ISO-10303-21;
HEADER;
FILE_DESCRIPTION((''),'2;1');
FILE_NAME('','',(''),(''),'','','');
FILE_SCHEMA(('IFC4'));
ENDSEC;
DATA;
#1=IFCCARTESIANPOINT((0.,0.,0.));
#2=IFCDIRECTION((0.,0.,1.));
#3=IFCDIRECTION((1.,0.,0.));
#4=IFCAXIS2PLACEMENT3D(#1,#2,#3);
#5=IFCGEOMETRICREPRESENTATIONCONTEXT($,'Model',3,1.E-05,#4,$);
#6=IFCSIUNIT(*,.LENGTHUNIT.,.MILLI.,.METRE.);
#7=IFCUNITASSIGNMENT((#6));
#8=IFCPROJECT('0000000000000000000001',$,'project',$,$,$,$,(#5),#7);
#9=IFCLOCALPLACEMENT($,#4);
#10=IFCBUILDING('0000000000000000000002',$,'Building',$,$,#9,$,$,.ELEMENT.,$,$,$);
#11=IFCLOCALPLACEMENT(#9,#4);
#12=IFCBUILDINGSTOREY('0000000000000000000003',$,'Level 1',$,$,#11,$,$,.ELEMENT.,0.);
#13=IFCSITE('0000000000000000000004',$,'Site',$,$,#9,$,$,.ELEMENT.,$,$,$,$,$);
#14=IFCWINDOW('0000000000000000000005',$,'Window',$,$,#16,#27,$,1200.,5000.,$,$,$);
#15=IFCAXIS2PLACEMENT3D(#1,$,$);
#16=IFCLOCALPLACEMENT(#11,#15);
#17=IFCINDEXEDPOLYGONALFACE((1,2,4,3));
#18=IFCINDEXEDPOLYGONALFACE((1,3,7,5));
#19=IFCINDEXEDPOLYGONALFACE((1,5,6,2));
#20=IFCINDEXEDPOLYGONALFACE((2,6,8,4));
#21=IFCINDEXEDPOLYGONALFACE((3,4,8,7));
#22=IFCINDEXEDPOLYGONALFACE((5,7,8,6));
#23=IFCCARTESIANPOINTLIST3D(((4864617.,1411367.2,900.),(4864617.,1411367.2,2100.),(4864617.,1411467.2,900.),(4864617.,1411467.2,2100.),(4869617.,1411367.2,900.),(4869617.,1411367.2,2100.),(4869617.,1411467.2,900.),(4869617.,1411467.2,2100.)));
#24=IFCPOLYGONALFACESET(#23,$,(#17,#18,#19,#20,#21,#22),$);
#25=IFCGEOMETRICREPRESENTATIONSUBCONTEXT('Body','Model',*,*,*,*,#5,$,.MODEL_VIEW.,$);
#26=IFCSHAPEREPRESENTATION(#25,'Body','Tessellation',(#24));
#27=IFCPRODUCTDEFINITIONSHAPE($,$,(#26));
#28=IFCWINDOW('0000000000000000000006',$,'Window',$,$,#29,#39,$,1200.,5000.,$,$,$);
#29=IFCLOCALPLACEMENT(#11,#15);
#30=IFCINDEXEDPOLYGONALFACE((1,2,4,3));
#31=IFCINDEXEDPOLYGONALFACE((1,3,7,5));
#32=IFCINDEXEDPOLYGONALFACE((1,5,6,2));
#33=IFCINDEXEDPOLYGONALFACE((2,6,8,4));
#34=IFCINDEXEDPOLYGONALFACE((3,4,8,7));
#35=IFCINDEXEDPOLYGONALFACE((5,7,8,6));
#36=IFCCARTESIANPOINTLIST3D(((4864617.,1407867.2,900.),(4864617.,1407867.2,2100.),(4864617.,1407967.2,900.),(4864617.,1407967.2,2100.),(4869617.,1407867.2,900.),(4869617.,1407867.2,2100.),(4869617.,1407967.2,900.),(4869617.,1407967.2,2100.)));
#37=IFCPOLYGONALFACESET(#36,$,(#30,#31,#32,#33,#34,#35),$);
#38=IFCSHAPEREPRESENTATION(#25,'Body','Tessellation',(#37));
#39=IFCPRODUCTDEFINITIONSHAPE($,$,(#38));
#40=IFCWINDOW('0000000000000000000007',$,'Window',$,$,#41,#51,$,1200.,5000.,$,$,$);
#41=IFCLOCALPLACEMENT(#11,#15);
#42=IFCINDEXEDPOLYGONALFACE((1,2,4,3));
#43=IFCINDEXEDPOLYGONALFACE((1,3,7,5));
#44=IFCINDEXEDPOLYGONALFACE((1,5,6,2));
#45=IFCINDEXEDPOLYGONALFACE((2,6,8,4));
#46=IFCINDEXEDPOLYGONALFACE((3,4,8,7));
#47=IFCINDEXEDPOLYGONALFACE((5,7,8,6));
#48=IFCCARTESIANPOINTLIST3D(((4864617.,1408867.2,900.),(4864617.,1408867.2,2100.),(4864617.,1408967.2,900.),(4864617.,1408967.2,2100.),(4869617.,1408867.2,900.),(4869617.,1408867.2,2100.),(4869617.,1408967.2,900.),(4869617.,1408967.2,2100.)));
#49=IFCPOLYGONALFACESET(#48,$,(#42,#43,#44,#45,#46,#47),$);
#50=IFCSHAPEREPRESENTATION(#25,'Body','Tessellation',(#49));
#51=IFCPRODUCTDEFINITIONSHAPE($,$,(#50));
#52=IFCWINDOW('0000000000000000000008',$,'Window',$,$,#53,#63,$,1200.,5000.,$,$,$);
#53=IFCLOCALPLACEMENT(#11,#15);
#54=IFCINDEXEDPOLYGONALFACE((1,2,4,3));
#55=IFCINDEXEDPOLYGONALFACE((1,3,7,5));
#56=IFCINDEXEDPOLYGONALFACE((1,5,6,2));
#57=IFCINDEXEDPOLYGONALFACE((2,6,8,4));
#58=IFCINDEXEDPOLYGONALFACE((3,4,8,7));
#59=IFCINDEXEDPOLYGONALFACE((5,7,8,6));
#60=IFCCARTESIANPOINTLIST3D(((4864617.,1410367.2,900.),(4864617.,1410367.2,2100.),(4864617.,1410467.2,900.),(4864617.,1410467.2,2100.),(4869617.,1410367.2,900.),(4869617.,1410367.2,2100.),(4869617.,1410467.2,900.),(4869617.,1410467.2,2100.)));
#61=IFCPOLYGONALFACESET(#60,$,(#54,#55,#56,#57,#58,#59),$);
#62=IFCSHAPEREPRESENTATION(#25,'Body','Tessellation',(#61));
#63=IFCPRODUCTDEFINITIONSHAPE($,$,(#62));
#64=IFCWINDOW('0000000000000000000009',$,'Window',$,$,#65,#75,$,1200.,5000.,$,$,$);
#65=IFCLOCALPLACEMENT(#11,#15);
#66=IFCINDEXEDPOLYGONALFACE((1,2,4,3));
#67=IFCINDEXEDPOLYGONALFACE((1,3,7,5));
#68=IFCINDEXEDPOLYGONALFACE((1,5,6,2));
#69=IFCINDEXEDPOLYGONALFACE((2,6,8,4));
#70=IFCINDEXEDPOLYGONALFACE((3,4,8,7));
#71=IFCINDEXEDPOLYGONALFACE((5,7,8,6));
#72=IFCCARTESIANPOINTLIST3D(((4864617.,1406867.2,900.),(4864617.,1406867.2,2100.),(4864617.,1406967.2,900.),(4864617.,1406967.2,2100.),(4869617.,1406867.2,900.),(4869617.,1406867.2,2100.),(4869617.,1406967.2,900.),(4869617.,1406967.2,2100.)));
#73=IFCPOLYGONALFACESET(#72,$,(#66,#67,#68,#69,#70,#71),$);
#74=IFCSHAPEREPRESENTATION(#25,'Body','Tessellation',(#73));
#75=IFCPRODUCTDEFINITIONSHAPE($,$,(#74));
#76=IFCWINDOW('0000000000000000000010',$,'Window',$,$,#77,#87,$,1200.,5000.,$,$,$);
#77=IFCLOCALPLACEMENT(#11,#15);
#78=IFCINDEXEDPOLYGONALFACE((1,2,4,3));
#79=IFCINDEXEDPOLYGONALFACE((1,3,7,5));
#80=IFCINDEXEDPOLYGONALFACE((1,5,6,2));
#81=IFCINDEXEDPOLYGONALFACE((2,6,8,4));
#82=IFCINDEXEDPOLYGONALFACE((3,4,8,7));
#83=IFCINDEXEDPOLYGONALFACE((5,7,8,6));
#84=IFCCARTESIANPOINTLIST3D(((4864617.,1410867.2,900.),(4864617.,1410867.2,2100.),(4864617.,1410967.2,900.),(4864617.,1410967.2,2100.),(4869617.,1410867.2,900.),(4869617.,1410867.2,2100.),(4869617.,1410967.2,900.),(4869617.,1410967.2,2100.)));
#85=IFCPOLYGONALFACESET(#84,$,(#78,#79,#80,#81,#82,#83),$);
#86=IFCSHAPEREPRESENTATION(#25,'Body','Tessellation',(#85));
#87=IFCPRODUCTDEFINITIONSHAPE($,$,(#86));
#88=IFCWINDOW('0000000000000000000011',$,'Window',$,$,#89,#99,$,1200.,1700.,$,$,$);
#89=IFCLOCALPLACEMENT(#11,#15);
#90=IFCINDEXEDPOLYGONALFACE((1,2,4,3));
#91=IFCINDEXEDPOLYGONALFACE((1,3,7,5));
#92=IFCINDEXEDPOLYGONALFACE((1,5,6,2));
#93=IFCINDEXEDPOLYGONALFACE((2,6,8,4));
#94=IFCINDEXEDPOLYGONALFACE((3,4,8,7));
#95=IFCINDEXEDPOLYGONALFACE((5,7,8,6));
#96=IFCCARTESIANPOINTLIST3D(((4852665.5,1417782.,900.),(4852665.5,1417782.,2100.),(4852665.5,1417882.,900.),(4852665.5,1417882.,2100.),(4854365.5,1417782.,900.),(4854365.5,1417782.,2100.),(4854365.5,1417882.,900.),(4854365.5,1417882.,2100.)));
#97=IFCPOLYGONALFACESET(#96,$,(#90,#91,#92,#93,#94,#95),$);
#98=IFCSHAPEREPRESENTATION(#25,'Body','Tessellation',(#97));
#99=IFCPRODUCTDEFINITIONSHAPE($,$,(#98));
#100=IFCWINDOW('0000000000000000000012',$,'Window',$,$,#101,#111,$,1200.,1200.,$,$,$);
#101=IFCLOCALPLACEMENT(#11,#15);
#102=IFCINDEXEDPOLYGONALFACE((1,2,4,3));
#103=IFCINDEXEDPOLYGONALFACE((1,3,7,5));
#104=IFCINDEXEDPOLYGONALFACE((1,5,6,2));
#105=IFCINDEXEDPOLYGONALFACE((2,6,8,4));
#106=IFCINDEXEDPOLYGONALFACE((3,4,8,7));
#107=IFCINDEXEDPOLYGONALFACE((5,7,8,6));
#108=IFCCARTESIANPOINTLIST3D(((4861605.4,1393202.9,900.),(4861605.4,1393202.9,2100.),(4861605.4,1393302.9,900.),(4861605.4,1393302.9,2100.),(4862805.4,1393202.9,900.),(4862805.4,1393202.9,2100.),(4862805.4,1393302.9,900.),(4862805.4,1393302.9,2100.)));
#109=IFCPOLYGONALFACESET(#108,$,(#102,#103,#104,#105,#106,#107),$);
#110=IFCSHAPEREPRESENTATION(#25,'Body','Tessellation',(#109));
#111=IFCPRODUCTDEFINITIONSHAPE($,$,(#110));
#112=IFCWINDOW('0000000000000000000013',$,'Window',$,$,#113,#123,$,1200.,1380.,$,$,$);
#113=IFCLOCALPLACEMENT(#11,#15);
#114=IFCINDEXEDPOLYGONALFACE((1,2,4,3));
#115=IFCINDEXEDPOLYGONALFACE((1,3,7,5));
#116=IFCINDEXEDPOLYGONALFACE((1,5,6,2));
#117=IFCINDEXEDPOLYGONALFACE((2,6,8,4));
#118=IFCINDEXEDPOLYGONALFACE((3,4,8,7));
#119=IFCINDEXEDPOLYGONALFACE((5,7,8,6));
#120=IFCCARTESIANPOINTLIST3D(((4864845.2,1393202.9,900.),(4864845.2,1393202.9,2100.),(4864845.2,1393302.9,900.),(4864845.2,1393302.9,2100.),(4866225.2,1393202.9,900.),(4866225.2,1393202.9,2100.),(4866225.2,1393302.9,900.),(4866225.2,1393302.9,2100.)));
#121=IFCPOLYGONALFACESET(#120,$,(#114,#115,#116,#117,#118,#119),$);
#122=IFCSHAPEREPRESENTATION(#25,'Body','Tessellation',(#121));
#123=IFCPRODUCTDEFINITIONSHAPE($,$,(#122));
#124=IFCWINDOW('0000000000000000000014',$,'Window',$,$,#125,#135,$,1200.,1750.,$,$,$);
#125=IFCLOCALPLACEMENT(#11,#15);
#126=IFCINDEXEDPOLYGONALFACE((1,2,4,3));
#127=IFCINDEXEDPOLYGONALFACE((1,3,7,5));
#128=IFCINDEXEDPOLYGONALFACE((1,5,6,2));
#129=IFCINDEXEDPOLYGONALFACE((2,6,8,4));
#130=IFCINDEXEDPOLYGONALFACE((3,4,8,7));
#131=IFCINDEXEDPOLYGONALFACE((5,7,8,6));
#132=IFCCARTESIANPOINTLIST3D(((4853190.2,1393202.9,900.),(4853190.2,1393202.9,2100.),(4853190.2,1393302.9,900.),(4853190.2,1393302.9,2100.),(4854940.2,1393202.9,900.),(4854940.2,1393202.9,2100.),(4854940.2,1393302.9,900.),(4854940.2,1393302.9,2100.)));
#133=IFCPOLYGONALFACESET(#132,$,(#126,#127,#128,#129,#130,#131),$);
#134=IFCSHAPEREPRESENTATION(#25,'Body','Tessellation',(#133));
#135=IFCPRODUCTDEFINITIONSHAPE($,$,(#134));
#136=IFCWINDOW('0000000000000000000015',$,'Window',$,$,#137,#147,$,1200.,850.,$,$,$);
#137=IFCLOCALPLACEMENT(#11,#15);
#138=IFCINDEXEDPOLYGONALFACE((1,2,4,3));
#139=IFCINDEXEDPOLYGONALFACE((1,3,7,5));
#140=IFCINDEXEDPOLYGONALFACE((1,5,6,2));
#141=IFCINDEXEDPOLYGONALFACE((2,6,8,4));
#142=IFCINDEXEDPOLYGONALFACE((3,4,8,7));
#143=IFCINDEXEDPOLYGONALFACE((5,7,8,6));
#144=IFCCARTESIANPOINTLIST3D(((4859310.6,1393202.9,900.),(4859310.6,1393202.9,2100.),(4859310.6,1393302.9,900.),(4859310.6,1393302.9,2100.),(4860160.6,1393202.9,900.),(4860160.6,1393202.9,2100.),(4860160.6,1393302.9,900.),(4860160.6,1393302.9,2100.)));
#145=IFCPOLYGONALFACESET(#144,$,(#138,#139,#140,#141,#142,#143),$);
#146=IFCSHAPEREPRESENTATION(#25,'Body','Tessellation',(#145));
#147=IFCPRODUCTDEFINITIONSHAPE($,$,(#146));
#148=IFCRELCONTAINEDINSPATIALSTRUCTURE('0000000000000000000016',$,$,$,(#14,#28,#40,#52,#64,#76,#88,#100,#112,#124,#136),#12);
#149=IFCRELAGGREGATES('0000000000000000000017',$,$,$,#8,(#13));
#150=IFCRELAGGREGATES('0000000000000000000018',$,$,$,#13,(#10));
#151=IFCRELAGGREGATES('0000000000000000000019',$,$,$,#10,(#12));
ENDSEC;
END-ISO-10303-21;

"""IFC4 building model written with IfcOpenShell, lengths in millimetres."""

from ifc_helpers import new_model, si_unit, frame, frame_2d, origin_with_axes, place, context, subcontext, project, spatial, rectangle, extrude, element, save


model = new_model("IFC4")

# Units and contexts
model_context = context("Model", 3, precision=1e-05, world=origin_with_axes())
body_context = subcontext(model_context, "Body", "Model", "MODEL_VIEW")
ifc_project = project(units=[si_unit("LENGTHUNIT", "METRE", prefix="MILLI")], contexts=[model_context])

# Site, building, storey
placement = place(None, origin_with_axes())
site = spatial("IfcSite", under=ifc_project, at=placement, Name="Site", CompositionType="ELEMENT")
building = spatial("IfcBuilding", under=site, at=placement, Name="Building", CompositionType="ELEMENT")
storey_placement = place(placement, origin_with_axes())
storey = spatial("IfcBuildingStorey", under=building, at=storey_placement, Name="Level 1", CompositionType="ELEMENT", Elevation=0.0)

# Windows
for number, where, z_axis, x_axis, name in (
    (1, (4864617.0, 1411417.2, 900.0), (0.0, 0.0, 1.0), (1.0, 0.0, 0.0), "Window"),
    (2, (4864617.0, 1407917.2, 900.0), (0.0, 0.0, 1.0), (1.0, 0.0, 0.0), "Window"),
    (3, (4864617.0, 1408917.2, 900.0), (0.0, 0.0, 1.0), (1.0, 0.0, 0.0), "Window"),
    (4, (4864617.0, 1410417.2, 900.0), (0.0, 0.0, 1.0), (1.0, 0.0, 0.0), "Window"),
    (5, (4864617.0, 1406917.2, 900.0), (0.0, 0.0, 1.0), (1.0, 0.0, 0.0), "Window"),
    (6, (4864617.0, 1410917.2, 900.0), (0.0, 0.0, 1.0), (1.0, 0.0, 0.0), "Window"),
):
    element("IfcWindow", number, at=place(placement, frame(where, z_axis=z_axis, x_axis=x_axis)), inside=storey, Name=name, OverallHeight=1200.0, OverallWidth=5000.0, context=body_context, shape_type="SweptSolid", body=[
        extrude(rectangle(XDim=5000.0, YDim=100.0, at=frame_2d((2500.0, 0.0), x_axis=(1.0, 0.0))), origin_with_axes(), (0.0, 0.0, 1.0), 1200.0),
    ])
window_1_placement = place(placement, frame((4854365.5, 1417832.0, 900.0), z_axis=(0.0, 0.0, 1.0), x_axis=(-1.0, 0.0, 0.0)))
element("IfcWindow", 7, at=window_1_placement, inside=storey, Name="Window", OverallHeight=1200.0, OverallWidth=1700.0, context=body_context, shape_type="SweptSolid", body=[
    extrude(rectangle(XDim=1700.0, YDim=100.0, at=frame_2d((850.0, 0.0), x_axis=(1.0, 0.0))), origin_with_axes(), (0.0, 0.0, 1.0), 1200.0),
])
window_2_placement = place(placement, frame((4861605.4, 1393252.9, 900.0), z_axis=(0.0, 0.0, 1.0), x_axis=(1.0, 0.0, 0.0)))
element("IfcWindow", 8, at=window_2_placement, inside=storey, Name="Window", OverallHeight=1200.0, OverallWidth=1200.0, context=body_context, shape_type="SweptSolid", body=[
    extrude(rectangle(XDim=1200.0, YDim=100.0, at=frame_2d((600.0, 0.0), x_axis=(1.0, 0.0))), origin_with_axes(), (0.0, 0.0, 1.0), 1200.0),
])
window_3_placement = place(placement, frame((4864845.2, 1393252.9, 900.0), z_axis=(0.0, 0.0, 1.0), x_axis=(1.0, 0.0, 0.0)))
element("IfcWindow", 9, at=window_3_placement, inside=storey, Name="Window", OverallHeight=1200.0, OverallWidth=1380.0, context=body_context, shape_type="SweptSolid", body=[
    extrude(rectangle(XDim=1380.0, YDim=100.0, at=frame_2d((690.0, 0.0), x_axis=(1.0, 0.0))), origin_with_axes(), (0.0, 0.0, 1.0), 1200.0),
])
window_4_placement = place(placement, frame((4853190.2, 1393252.9, 900.0), z_axis=(0.0, 0.0, 1.0), x_axis=(1.0, 0.0, 0.0)))
element("IfcWindow", 10, at=window_4_placement, inside=storey, Name="Window", OverallHeight=1200.0, OverallWidth=1750.0, context=body_context, shape_type="SweptSolid", body=[
    extrude(rectangle(XDim=1750.0, YDim=100.0, at=frame_2d((875.0, 0.0), x_axis=(1.0, 0.0))), origin_with_axes(), (0.0, 0.0, 1.0), 1200.0),
])
window_5_placement = place(placement, frame((4859310.6, 1393252.9, 900.0), z_axis=(0.0, 0.0, 1.0), x_axis=(1.0, 0.0, 0.0)))
element("IfcWindow", 11, at=window_5_placement, inside=storey, Name="Window", OverallHeight=1200.0, OverallWidth=850.0, context=body_context, shape_type="SweptSolid", body=[
    extrude(rectangle(XDim=850.0, YDim=100.0, at=frame_2d((425.0, 0.0), x_axis=(1.0, 0.0))), origin_with_axes(), (0.0, 0.0, 1.0), 1200.0),
])

save(model, "model.ifc")
